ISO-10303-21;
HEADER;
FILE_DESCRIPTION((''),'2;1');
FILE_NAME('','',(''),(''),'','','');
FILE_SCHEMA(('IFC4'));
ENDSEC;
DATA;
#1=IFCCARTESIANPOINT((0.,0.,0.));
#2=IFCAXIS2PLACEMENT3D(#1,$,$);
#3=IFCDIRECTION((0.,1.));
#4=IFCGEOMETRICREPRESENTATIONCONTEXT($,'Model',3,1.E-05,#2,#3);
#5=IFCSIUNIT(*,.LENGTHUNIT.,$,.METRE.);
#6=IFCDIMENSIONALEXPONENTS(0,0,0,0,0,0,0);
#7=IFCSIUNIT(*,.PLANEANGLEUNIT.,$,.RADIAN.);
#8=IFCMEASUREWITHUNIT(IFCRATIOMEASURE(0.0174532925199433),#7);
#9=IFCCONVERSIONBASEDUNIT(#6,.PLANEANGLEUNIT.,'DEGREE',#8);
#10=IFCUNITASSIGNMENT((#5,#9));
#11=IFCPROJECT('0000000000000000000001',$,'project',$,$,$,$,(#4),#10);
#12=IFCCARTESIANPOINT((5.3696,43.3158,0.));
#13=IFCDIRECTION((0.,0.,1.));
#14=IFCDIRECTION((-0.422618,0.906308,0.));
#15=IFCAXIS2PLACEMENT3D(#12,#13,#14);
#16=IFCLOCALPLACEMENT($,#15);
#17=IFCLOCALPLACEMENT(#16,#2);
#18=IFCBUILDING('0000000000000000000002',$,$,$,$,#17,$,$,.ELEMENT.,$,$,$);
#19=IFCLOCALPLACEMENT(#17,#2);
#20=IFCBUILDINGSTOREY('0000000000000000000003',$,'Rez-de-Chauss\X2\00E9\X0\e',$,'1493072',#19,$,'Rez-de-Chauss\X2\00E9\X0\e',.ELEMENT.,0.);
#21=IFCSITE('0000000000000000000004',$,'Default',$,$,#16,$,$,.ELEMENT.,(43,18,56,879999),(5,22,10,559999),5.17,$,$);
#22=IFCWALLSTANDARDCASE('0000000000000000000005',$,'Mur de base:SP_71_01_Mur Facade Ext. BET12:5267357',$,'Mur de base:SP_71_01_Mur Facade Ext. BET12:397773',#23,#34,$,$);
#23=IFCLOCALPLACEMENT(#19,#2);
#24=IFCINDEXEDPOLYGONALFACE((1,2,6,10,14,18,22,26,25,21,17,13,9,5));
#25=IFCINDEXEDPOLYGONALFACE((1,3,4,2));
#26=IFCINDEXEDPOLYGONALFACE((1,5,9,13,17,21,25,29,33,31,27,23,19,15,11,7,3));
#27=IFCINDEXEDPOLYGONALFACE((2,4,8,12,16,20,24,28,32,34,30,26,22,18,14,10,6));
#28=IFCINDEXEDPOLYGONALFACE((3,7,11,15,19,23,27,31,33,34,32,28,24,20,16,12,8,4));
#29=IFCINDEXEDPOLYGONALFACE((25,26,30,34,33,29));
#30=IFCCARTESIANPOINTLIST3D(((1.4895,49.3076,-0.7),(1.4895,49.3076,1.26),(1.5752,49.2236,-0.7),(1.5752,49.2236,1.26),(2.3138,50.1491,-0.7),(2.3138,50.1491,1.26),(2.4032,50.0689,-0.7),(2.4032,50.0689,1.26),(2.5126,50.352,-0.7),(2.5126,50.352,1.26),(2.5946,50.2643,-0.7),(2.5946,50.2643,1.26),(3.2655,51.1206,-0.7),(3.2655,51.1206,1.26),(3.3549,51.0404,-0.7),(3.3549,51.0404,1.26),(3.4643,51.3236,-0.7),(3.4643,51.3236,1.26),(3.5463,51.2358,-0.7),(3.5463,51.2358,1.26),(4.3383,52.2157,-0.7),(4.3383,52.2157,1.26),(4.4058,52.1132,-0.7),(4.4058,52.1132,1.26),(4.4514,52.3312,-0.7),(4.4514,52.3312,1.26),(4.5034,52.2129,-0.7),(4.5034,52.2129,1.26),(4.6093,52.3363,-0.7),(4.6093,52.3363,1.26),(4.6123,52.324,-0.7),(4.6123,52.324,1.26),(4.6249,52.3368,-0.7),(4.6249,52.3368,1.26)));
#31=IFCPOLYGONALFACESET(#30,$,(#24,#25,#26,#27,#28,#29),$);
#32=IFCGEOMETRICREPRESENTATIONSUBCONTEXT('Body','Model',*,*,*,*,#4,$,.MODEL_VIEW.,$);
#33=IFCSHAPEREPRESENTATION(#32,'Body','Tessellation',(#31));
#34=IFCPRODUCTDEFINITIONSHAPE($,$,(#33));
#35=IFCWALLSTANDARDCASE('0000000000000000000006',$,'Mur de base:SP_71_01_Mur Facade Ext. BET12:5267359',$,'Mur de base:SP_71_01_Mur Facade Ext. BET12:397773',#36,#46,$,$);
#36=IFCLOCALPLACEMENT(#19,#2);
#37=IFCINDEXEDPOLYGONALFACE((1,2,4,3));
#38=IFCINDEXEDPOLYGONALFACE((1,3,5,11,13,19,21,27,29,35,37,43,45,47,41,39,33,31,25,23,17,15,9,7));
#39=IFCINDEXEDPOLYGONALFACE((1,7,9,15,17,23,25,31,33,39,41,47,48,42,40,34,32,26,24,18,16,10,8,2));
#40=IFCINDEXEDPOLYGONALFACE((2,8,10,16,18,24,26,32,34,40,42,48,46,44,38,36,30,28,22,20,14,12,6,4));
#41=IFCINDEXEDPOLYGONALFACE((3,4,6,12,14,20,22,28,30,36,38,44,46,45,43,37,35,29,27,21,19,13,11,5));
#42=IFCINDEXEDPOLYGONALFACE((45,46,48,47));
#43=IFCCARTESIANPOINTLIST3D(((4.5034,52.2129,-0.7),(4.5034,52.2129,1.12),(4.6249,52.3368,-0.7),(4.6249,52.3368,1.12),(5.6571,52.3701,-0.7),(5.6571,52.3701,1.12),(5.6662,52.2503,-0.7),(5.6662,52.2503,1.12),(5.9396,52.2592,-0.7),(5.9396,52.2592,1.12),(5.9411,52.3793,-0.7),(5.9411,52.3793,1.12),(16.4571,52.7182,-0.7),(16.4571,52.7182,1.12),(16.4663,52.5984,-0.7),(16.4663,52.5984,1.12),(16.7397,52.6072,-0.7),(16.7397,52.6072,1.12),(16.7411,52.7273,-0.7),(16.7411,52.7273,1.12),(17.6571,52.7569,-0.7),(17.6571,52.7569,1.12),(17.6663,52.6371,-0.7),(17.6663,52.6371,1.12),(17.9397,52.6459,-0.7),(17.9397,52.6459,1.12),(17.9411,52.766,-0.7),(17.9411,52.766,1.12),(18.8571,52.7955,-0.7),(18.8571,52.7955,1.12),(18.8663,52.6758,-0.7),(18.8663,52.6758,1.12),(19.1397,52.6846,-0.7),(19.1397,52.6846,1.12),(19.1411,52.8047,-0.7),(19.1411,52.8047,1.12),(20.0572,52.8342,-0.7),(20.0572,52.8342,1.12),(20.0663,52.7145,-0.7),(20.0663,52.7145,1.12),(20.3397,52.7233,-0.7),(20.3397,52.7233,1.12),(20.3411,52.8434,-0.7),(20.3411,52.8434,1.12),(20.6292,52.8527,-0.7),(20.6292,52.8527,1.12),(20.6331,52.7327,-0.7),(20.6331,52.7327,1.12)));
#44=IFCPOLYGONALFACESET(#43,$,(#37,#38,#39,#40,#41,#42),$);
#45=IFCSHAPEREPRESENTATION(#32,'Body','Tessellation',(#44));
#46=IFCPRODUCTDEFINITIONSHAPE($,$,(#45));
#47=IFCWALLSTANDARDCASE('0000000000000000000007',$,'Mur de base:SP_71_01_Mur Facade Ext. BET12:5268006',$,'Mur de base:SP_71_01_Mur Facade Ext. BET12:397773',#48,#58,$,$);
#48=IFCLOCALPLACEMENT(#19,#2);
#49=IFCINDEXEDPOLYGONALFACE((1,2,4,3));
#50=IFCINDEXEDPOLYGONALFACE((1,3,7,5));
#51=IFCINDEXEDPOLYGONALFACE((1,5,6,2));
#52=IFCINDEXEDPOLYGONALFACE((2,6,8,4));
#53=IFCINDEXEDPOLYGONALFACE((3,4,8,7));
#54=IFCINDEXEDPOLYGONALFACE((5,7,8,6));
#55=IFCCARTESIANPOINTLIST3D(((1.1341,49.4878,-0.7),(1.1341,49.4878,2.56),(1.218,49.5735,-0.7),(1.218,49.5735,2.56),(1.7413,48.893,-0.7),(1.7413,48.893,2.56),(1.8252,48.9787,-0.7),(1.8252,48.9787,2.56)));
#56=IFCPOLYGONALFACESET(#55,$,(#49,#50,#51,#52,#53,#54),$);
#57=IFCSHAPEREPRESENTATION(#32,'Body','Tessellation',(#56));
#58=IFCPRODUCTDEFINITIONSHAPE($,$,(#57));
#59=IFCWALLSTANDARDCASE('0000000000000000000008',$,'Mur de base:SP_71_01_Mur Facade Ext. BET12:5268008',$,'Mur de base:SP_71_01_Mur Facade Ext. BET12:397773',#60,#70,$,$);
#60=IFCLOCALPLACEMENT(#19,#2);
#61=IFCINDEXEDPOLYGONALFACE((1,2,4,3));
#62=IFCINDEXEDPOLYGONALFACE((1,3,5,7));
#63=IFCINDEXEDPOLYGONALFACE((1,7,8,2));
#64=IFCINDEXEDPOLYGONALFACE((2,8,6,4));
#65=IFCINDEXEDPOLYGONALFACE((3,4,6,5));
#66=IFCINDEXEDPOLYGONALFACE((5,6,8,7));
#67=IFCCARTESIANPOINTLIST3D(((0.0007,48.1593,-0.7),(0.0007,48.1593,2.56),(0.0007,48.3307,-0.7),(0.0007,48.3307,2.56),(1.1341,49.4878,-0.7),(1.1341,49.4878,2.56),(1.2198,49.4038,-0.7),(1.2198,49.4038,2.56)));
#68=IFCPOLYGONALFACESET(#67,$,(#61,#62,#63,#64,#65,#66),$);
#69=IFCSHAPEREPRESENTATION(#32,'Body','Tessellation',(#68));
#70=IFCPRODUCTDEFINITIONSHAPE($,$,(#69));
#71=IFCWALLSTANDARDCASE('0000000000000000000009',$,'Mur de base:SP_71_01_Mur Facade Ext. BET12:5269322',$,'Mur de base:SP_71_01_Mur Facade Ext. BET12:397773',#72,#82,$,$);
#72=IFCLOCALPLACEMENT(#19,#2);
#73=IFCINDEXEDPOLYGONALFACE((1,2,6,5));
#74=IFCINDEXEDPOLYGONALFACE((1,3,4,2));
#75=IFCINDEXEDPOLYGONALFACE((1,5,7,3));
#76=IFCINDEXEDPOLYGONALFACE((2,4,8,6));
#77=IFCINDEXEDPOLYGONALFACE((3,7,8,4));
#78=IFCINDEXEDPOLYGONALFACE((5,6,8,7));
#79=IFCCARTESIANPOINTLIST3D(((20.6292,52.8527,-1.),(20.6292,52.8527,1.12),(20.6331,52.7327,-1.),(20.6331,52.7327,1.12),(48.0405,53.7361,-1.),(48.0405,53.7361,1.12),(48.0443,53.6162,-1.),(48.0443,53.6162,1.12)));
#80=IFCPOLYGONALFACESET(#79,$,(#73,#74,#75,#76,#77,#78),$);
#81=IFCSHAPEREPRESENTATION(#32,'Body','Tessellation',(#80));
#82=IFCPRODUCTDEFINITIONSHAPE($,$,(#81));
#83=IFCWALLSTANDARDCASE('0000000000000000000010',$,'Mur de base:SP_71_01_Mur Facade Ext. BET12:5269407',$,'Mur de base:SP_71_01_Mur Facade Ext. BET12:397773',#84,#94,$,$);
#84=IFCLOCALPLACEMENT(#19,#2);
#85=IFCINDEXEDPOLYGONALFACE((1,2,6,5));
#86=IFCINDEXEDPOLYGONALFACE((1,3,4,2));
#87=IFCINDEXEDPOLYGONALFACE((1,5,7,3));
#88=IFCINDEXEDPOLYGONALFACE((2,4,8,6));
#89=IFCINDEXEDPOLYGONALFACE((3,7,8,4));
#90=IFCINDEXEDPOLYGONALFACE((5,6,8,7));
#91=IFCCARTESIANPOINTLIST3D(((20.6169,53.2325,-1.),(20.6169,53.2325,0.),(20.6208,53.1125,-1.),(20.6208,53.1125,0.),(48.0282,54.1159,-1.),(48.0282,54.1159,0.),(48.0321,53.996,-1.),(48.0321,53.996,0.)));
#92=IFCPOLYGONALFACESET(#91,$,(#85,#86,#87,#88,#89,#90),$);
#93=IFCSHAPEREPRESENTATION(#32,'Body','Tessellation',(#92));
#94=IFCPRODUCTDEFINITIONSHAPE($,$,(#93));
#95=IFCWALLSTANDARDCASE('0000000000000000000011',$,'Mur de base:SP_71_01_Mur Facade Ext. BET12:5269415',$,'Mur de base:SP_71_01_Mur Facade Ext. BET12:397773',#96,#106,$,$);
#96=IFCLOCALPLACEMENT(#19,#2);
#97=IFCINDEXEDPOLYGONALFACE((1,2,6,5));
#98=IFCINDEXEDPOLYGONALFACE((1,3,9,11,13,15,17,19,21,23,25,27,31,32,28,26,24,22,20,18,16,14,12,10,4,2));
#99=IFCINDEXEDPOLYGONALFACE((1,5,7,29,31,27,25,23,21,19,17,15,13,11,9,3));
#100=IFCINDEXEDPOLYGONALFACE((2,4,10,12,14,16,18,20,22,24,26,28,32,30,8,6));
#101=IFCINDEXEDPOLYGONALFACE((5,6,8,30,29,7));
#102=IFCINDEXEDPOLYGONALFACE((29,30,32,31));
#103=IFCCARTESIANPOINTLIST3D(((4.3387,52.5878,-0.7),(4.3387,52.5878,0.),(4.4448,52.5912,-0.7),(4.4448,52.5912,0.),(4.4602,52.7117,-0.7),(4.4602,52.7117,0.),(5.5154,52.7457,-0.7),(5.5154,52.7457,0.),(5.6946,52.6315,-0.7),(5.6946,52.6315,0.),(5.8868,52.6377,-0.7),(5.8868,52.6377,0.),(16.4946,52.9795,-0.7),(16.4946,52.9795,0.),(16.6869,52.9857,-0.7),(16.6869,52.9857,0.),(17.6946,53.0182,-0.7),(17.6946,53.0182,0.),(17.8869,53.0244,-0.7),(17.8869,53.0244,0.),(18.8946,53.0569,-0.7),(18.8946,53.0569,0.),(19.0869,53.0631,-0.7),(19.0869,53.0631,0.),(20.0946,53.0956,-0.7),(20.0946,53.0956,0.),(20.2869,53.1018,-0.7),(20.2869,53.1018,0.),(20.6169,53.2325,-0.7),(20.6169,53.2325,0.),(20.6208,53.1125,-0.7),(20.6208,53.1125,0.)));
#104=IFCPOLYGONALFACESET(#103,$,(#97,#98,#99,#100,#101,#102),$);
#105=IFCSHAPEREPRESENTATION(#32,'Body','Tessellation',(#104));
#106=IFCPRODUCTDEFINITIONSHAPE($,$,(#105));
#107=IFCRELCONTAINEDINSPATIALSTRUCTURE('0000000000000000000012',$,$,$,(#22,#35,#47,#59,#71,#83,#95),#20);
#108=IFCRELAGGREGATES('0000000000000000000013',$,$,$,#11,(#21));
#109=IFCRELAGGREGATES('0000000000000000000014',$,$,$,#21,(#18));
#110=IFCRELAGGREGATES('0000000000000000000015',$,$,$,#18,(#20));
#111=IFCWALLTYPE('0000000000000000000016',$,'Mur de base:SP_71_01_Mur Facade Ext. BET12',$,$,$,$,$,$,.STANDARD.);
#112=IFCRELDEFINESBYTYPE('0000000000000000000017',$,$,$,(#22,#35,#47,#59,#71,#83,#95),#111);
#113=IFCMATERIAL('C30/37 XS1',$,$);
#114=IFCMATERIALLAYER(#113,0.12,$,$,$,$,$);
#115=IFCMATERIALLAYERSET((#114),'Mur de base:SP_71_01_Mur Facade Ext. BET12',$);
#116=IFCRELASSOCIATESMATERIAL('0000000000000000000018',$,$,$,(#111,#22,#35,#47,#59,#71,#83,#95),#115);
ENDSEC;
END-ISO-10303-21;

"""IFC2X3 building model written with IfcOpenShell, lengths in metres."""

from ifc_helpers import new_model, entity, si_unit, converted_unit, direction, frame, frame_2d, origin, place, context, subcontext, project, spatial, polyline, rectangle, outline, extrude, clip, halfspace, material, layer, layer_set, layer_usage, type_object, element, save


model = new_model("IFC2X3")

# Units and contexts
model_context = context("Model", 3, precision=1e-05, world=origin(), true_north=direction((0.0, 1.0)))
body_context = subcontext(model_context, "Body", "Model", "MODEL_VIEW")
ifc_project = project(units=[si_unit("LENGTHUNIT", "METRE"), converted_unit("PLANEANGLEUNIT", "DEGREE", entity("IfcRatioMeasure", 0.0174532925199433), si_unit("PLANEANGLEUNIT", "RADIAN"), dimensions=[0, 0, 0, 0, 0, 0, 0])], contexts=[model_context])

# Site, building, storey
site_placement = place(None, frame((5.3696, 43.3158, 0.0), z_axis=(0.0, 0.0, 1.0), x_axis=(-0.422618, 0.906308, 0.0)))
site = spatial("IfcSite", under=ifc_project, at=site_placement, Name="Default", CompositionType="ELEMENT", RefLatitude=(43, 18, 56, 879999), RefLongitude=(5, 22, 10, 559999), RefElevation=5.17)
building_placement = place(site_placement, origin())
building = spatial("IfcBuilding", under=site, at=building_placement, CompositionType="ELEMENT")
storey_placement = place(building_placement, origin())
storey = spatial("IfcBuildingStorey", under=building, at=storey_placement, Name="Rez-de-Chaussée", ObjectType="1493072", LongName="Rez-de-Chaussée", CompositionType="ELEMENT", Elevation=0.0)

# Walls
ifc_material_1 = material(Name="C30/37 XS1")
ifc_layer_1 = layer(ifc_material_1, 0.12)
ifc_layer_set_1 = layer_set([ifc_layer_1], Name="Mur de base:SP_71_01_Mur Facade Ext. BET12")
ifc_layer_usage_1 = layer_usage(ifc_layer_set_1, "AXIS2", "NEGATIVE", 0.06)
wall_type_1 = type_object("IfcWallType", Name="Mur de base:SP_71_01_Mur Facade Ext. BET12", PredefinedType="STANDARD", material=ifc_layer_set_1)
wall_1_placement = place(storey_placement, frame((1.5323, 49.2656, -0.7), z_axis=(0.0, 0.0, 1.0), x_axis=(0.699776, 0.714363, 0.0)))
element("IfcWallStandardCase", 1, at=wall_1_placement, inside=storey, type_object=wall_type_1, material=ifc_layer_usage_1, Name="Mur de base:SP_71_01_Mur Facade Ext. BET12:5267357", ObjectType="Mur de base:SP_71_01_Mur Facade Ext. BET12:397773", context=body_context, shape_type="SweptSolid", body=[
    extrude(outline(polyline([(4.3581, -0.06), (4.3468, -0.0492), (4.2327, 0.06), (4.071, 0.06), (2.8221, 0.06), (2.5379, 0.06), (1.4621, 0.06), (1.1779, 0.06), (0.0, 0.06), (0.0, -0.06), (1.1832, -0.06), (1.4568, -0.06), (2.5432, -0.06), (2.8168, -0.06), (4.045, -0.06), (4.1845, -0.06), (4.34, -0.06), (4.3581, -0.06)])), origin(), (0.0, 0.0, 1.0), 1.96),
])
ifc_layer_usage_2 = layer_usage(ifc_layer_set_1, "AXIS2", "NEGATIVE", 0.06)
wall_2_placement = place(storey_placement, frame((4.5015, 52.2728, -0.7), z_axis=(0.0, 0.0, 1.0), x_axis=(0.999481, 0.032213, 0.0)))
element("IfcWallStandardCase", 2, at=wall_2_placement, inside=storey, type_object=wall_type_1, material=ifc_layer_usage_2, Name="Mur de base:SP_71_01_Mur Facade Ext. BET12:5267359", ObjectType="Mur de base:SP_71_01_Mur Facade Ext. BET12:397773", context=body_context, shape_type="SweptSolid", body=[
    extrude(outline(polyline([(16.138, -0.06), (16.138, 0.06), (15.8498, 0.06), (15.5657, 0.06), (14.6492, 0.06), (14.365, 0.06), (13.4485, 0.06), (13.1644, 0.06), (12.2479, 0.06), (11.9638, 0.06), (1.4423, 0.06), (1.1581, 0.06), (0.1254, 0.06), (0.0, -0.06), (1.1634, -0.06), (1.437, -0.06), (11.9691, -0.06), (12.2426, -0.06), (13.1697, -0.06), (13.4432, -0.06), (14.3703, -0.06), (14.6439, -0.06), (15.571, -0.06), (15.8445, -0.06), (16.138, -0.06)])), origin(), (0.0, 0.0, 1.0), 1.82),
])
ifc_layer_usage_3 = layer_usage(ifc_layer_set_1, "AXIS2", "NEGATIVE", 0.06)
wall_3_placement = place(storey_placement, frame((1.7833, 48.9358, -0.7), z_axis=(0.0, 0.0, 1.0), x_axis=(-0.714364, 0.699774, 0.0)))
element("IfcWallStandardCase", 3, at=wall_3_placement, inside=storey, type_object=wall_type_1, material=ifc_layer_usage_3, Name="Mur de base:SP_71_01_Mur Facade Ext. BET12:5268006", ObjectType="Mur de base:SP_71_01_Mur Facade Ext. BET12:397773", context=body_context, shape_type="Clipping", body=[
    clip(extrude(rectangle(XDim=0.85, YDim=0.12, at=frame_2d((0.425, 0.0), x_axis=(-1.0, 0.0))), origin(), (0.0, 0.0, 1.0), 3.26), halfspace(frame((0.0, 0.0, -0.7)), True)),
])
ifc_layer_usage_4 = layer_usage(ifc_layer_set_1, "AXIS2", "NEGATIVE", 0.06)
wall_4_placement = place(storey_placement, frame((1.1769, 49.4458, -0.7), z_axis=(0.0, 0.0, 1.0), x_axis=(-0.699774, -0.714364, 0.0)))
element("IfcWallStandardCase", 4, at=wall_4_placement, inside=storey, type_object=wall_type_1, material=ifc_layer_usage_4, Name="Mur de base:SP_71_01_Mur Facade Ext. BET12:5268008", ObjectType="Mur de base:SP_71_01_Mur Facade Ext. BET12:397773", context=body_context, shape_type="Clipping", body=[
    clip(extrude(outline(polyline([(1.6197, -0.06), (1.7422, 0.06), (0.0, 0.06), (0.0, -0.06), (1.6197, -0.06)])), origin(), (0.0, 0.0, 1.0), 3.26), halfspace(frame((0.0, 0.0, -0.7)), True)),
])
ifc_layer_usage_5 = layer_usage(ifc_layer_set_1, "AXIS2", "NEGATIVE", 0.06)
wall_5_placement = place(storey_placement, frame((20.6311, 52.7927, -1.0), z_axis=(0.0, 0.0, 1.0), x_axis=(0.999481, 0.032213, 0.0)))
element("IfcWallStandardCase", 5, at=wall_5_placement, inside=storey, type_object=wall_type_1, material=ifc_layer_usage_5, Name="Mur de base:SP_71_01_Mur Facade Ext. BET12:5269322", ObjectType="Mur de base:SP_71_01_Mur Facade Ext. BET12:397773", context=body_context, shape_type="SweptSolid", body=[
    extrude(rectangle(XDim=27.4255, YDim=0.12, at=frame_2d((13.7127, 0.0), x_axis=(-1.0, 0.0))), origin(), (0.0, 0.0, 1.0), 2.12),
])

# Walls
ifc_layer_usage_6 = layer_usage(ifc_layer_set_1, "AXIS2", "NEGATIVE", 0.06)
wall_6_placement = place(storey_placement, frame((20.6189, 53.1725, -1.0), z_axis=(0.0, 0.0, 1.0), x_axis=(0.999481, 0.032213, 0.0)))
element("IfcWallStandardCase", 6, at=wall_6_placement, inside=storey, type_object=wall_type_1, material=ifc_layer_usage_6, Name="Mur de base:SP_71_01_Mur Facade Ext. BET12:5269407", ObjectType="Mur de base:SP_71_01_Mur Facade Ext. BET12:397773", context=body_context, shape_type="SweptSolid", body=[
    extrude(rectangle(XDim=27.4255, YDim=0.12, at=frame_2d((13.7127, 0.0), x_axis=(-1.0, 0.0))), origin(), (0.0, 0.0, 1.0), 1.0),
])
ifc_layer_usage_7 = layer_usage(ifc_layer_set_1, "AXIS2", "NEGATIVE", 0.06)
wall_7_placement = place(storey_placement, frame((4.3368, 52.6477, -0.7), z_axis=(0.0, 0.0, 1.0), x_axis=(0.999481, 0.032213, 0.0)))
element("IfcWallStandardCase", 7, at=wall_7_placement, inside=storey, type_object=wall_type_1, material=ifc_layer_usage_7, Name="Mur de base:SP_71_01_Mur Facade Ext. BET12:5269415", ObjectType="Mur de base:SP_71_01_Mur Facade Ext. BET12:397773", context=body_context, shape_type="SweptSolid", body=[
    extrude(outline(polyline([(16.2906, -0.06), (16.2906, 0.06), (1.1811, 0.06), (0.1254, 0.06), (0.0, -0.06), (0.1061, -0.06), (1.3566, -0.06), (1.5489, -0.06), (12.1622, -0.06), (12.3546, -0.06), (13.3628, -0.06), (13.5552, -0.06), (14.5635, -0.06), (14.7558, -0.06), (15.7641, -0.06), (15.9565, -0.06), (16.2906, -0.06)])), origin(), (0.0, 0.0, 1.0), 0.7),
])

save(model, "model.ifc")
